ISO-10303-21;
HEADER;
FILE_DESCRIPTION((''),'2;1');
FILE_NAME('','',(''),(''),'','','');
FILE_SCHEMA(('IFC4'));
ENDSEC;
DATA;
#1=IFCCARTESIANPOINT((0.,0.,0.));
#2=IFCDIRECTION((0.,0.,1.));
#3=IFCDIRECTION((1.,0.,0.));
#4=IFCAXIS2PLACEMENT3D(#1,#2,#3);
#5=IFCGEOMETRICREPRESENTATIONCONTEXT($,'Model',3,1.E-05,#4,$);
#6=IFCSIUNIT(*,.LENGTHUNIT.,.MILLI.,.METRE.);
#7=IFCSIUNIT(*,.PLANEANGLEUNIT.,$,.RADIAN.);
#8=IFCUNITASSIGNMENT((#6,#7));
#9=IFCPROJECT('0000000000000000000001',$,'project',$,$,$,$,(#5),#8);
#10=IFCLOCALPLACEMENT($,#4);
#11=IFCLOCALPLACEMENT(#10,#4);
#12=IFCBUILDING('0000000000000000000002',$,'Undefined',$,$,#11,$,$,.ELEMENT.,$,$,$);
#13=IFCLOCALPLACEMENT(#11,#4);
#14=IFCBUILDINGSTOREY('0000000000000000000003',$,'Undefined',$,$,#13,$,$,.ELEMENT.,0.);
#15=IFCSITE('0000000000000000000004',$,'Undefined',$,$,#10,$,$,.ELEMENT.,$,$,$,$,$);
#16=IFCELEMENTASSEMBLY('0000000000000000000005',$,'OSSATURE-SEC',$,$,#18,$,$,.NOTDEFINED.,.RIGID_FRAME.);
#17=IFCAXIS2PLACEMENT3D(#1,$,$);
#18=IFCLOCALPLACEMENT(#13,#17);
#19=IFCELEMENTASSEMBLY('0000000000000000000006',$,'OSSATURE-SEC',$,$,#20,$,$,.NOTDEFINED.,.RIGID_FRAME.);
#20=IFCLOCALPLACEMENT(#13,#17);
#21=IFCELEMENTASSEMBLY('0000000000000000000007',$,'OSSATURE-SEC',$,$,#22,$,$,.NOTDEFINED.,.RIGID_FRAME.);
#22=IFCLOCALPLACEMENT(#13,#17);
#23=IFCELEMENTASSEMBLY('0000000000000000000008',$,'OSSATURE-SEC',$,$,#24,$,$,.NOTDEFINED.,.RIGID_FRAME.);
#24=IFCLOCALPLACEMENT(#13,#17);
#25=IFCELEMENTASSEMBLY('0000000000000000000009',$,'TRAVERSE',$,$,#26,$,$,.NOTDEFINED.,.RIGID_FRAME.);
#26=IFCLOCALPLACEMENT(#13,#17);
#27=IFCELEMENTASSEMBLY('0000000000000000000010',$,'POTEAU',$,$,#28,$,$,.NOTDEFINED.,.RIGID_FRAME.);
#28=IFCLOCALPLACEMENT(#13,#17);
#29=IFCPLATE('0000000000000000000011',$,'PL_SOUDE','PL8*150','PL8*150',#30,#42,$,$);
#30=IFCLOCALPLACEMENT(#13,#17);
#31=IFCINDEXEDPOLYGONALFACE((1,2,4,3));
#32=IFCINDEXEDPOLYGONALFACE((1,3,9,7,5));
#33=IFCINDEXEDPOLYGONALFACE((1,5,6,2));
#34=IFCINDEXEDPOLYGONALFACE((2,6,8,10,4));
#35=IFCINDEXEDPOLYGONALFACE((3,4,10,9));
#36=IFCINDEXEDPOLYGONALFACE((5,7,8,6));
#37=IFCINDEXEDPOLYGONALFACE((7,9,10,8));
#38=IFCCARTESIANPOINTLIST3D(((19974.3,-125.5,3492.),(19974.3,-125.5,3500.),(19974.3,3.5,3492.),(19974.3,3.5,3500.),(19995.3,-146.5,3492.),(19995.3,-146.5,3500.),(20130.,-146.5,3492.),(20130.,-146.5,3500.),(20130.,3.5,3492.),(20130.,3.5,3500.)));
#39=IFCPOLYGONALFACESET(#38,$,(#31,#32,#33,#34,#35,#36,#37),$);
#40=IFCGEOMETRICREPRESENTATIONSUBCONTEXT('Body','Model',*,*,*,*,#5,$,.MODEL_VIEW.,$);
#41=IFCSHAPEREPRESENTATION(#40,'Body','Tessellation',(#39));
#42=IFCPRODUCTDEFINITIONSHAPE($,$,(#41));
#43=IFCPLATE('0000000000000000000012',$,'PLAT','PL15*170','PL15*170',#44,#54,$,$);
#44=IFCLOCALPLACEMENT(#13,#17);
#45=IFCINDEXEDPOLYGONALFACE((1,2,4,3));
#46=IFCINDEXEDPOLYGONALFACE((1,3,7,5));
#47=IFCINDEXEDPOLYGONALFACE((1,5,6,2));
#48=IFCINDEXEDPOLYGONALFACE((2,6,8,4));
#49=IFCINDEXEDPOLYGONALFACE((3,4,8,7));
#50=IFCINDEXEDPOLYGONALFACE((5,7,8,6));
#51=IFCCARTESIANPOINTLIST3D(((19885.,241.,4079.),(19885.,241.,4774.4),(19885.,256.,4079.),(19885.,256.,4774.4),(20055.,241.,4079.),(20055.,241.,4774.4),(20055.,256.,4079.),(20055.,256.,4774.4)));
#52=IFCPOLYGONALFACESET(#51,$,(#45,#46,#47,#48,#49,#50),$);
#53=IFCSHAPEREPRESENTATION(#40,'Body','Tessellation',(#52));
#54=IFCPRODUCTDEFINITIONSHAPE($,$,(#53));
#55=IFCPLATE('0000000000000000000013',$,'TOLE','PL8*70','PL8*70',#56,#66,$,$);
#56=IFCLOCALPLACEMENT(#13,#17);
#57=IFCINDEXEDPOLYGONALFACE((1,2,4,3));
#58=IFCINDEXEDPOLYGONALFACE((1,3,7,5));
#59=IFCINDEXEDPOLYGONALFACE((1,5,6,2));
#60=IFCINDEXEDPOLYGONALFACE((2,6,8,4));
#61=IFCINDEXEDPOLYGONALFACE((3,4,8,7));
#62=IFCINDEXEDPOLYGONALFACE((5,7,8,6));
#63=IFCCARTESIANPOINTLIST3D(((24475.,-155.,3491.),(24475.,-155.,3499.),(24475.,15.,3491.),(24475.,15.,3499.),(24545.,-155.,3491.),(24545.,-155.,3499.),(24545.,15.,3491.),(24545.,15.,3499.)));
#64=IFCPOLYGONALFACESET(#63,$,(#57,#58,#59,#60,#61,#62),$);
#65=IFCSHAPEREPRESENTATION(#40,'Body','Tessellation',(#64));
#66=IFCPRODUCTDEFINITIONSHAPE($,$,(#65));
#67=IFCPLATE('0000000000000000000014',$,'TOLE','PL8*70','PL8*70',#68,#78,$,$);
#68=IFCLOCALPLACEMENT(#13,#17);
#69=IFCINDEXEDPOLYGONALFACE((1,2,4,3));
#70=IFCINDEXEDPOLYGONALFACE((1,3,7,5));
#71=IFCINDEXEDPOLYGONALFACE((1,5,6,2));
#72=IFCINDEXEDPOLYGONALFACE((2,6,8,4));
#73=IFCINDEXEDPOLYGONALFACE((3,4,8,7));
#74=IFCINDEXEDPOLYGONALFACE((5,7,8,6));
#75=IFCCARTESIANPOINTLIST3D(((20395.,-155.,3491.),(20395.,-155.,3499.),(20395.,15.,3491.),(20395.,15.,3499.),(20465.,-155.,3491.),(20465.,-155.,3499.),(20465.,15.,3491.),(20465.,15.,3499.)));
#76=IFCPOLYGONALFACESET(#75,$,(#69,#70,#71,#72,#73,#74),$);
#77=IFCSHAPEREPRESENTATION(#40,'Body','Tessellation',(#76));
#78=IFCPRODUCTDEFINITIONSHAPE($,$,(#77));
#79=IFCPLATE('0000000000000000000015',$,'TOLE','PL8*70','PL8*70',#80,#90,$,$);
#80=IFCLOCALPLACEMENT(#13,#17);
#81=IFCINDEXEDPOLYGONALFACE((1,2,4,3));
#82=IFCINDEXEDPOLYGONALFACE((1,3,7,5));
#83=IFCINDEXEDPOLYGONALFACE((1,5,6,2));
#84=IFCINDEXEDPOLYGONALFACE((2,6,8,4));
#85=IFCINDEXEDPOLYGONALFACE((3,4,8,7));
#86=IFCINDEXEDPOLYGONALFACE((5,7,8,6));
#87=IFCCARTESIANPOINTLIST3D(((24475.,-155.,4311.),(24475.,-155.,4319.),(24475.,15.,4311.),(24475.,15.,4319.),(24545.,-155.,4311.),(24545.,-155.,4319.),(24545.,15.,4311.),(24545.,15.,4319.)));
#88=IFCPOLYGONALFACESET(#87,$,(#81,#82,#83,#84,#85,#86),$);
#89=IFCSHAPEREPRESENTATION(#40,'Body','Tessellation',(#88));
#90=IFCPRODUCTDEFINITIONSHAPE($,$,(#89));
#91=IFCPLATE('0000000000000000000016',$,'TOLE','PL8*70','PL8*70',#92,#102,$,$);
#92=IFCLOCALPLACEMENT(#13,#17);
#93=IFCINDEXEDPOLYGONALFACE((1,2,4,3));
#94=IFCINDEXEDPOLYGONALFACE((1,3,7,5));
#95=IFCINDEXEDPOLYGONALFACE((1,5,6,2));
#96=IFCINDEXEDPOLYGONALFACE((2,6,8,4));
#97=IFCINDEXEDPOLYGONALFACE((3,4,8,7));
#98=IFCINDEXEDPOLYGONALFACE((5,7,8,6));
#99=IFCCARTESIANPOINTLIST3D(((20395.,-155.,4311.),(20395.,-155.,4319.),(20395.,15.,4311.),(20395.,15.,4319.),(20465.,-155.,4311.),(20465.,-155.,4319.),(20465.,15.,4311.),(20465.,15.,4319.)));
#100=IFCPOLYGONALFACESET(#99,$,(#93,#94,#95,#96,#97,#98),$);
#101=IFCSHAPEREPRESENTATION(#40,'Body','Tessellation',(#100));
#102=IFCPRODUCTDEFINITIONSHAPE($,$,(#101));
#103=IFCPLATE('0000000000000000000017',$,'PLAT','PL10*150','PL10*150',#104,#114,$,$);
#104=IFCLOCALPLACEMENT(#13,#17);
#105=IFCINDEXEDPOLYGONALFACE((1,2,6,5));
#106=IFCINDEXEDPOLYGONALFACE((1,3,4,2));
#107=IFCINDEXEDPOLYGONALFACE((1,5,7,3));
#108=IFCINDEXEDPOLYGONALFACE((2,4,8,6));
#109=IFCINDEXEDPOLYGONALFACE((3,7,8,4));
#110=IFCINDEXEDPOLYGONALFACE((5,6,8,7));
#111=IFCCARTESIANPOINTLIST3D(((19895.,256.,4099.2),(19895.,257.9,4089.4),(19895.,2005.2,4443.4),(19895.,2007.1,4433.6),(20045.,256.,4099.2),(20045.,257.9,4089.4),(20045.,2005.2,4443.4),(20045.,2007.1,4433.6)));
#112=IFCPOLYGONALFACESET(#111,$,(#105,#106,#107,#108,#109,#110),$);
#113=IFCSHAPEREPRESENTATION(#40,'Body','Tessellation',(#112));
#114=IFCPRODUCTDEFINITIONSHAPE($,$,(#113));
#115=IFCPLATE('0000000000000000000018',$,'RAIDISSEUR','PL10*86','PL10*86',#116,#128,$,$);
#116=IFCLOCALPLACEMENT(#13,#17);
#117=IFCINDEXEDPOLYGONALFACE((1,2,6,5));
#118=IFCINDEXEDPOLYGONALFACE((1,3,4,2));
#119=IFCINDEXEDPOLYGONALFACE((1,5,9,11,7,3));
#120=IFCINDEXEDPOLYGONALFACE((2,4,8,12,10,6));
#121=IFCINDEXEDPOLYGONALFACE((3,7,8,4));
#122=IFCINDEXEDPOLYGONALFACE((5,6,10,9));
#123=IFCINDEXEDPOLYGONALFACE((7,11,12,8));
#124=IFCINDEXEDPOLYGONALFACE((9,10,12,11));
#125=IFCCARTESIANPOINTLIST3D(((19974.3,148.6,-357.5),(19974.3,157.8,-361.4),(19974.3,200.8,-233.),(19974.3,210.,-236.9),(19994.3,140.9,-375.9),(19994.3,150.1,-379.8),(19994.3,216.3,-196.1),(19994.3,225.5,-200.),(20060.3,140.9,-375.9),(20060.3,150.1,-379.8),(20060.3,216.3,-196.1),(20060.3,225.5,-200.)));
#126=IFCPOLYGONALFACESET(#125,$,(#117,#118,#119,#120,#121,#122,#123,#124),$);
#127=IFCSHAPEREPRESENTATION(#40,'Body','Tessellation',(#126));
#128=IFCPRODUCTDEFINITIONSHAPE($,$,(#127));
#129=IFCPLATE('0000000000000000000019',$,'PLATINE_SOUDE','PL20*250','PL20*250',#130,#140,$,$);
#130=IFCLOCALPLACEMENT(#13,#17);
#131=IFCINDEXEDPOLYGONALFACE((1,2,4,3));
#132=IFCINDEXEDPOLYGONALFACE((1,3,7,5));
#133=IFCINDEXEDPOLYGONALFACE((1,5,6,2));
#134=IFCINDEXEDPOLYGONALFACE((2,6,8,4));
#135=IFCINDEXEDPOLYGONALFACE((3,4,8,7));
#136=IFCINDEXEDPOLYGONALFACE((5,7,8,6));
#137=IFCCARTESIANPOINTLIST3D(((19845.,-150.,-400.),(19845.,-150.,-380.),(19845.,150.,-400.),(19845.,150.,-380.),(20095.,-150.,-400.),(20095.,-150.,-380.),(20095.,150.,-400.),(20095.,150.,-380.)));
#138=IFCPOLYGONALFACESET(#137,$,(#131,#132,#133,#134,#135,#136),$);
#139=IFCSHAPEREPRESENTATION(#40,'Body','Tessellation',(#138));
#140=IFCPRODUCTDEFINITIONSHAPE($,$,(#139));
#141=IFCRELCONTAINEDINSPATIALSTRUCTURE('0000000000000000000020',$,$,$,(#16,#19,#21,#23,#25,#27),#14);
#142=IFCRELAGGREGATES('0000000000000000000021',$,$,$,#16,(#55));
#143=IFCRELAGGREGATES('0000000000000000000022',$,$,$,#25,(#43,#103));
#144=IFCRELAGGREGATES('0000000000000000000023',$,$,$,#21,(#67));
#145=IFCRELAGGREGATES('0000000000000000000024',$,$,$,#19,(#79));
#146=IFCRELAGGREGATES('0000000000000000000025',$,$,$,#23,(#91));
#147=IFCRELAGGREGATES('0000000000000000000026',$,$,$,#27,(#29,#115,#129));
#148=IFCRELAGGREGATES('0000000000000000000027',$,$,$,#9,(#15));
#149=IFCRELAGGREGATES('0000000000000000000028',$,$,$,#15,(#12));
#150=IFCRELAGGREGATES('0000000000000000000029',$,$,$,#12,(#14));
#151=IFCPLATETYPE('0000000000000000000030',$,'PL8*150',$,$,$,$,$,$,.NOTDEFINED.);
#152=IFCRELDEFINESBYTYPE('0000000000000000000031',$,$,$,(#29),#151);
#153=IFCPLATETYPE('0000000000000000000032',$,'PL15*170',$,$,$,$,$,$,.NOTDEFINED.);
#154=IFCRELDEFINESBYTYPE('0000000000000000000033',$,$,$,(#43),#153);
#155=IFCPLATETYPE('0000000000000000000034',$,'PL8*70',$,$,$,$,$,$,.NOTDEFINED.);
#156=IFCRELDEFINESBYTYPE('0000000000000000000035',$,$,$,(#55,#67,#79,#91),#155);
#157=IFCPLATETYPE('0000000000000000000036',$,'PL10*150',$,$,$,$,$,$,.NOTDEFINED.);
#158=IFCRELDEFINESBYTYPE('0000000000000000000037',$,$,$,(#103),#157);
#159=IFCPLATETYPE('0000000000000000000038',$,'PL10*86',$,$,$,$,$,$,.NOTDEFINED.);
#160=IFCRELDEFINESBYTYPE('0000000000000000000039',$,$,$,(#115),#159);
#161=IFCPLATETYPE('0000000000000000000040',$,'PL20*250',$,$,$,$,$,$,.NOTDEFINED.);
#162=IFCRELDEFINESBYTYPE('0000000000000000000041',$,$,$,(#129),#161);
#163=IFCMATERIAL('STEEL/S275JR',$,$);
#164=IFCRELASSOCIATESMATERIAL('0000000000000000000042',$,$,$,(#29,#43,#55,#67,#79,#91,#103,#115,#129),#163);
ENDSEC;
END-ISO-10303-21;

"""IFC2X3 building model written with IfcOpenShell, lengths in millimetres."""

from ifc_helpers import new_model, si_unit, frame, origin_with_axes, place, context, subcontext, project, spatial, polyline, outline, extrude, material, type_object, element, aggregate, save


model = new_model("IFC2X3")

# Units and contexts
model_context = context("Model", 3, precision=1e-05, world=origin_with_axes())
body_context = subcontext(model_context, "Body", "Model", "MODEL_VIEW")
ifc_project = project(units=[si_unit("LENGTHUNIT", "METRE", prefix="MILLI"), si_unit("PLANEANGLEUNIT", "RADIAN")], contexts=[model_context])

# Site, building, storey
site_placement = place(None, origin_with_axes())
site = spatial("IfcSite", under=ifc_project, at=site_placement, Name="Undefined", CompositionType="ELEMENT")
building_placement = place(site_placement, origin_with_axes())
building = spatial("IfcBuilding", under=site, at=building_placement, Name="Undefined", CompositionType="ELEMENT")
storey_placement = place(building_placement, origin_with_axes())
storey = spatial("IfcBuildingStorey", under=building, at=storey_placement, Name="Undefined", CompositionType="ELEMENT", Elevation=0.0)

# Element assemblies
assembly_1_placement = place(storey_placement, origin_with_axes())
assembly_1 = element("IfcElementAssembly", 1, at=assembly_1_placement, inside=storey, Name="OSSATURE-SEC", AssemblyPlace="NOTDEFINED", PredefinedType="RIGID_FRAME")
ifc_material_1 = material(Name="STEEL/S275JR")
assembly_2_placement = place(storey_placement, origin_with_axes())
assembly_2 = element("IfcElementAssembly", 2, at=assembly_2_placement, inside=storey, Name="OSSATURE-SEC", AssemblyPlace="NOTDEFINED", PredefinedType="RIGID_FRAME")

# Element assemblies
assembly_3_placement = place(storey_placement, origin_with_axes())
assembly_3 = element("IfcElementAssembly", 3, at=assembly_3_placement, inside=storey, Name="OSSATURE-SEC", AssemblyPlace="NOTDEFINED", PredefinedType="RIGID_FRAME")
assembly_4_placement = place(storey_placement, origin_with_axes())
assembly_4 = element("IfcElementAssembly", 4, at=assembly_4_placement, inside=storey, Name="OSSATURE-SEC", AssemblyPlace="NOTDEFINED", PredefinedType="RIGID_FRAME")
assembly_5_placement = place(storey_placement, origin_with_axes())
assembly_5 = element("IfcElementAssembly", 5, at=assembly_5_placement, inside=storey, Name="TRAVERSE", AssemblyPlace="NOTDEFINED", PredefinedType="RIGID_FRAME")

# Element assembly, plate
assembly_6_placement = place(storey_placement, origin_with_axes())
assembly_6 = element("IfcElementAssembly", 6, at=assembly_6_placement, inside=storey, Name="POTEAU", AssemblyPlace="NOTDEFINED", PredefinedType="RIGID_FRAME")
plate_type_1 = type_object("IfcPlateType", Name="PL8*150", PredefinedType="NOTDEFINED")
plate_1_placement = place(assembly_6_placement, frame((19974.3, -146.5, 3496.0), z_axis=(0.0, 0.0, 1.0), x_axis=(1.0, 0.0, 0.0)))
plate_1 = element("IfcPlate", 7, at=plate_1_placement, type_object=plate_type_1, material=ifc_material_1, Name="PL_SOUDE", Description="PL8*150", ObjectType="PL8*150", context=body_context, shape_type="SweptSolid", body=[
    extrude(outline(polyline([(0.0, 21.0), (21.0, 0.0), (155.7, 0.0), (155.7, 150.0), (0.0, 150.0), (0.0, 21.0)])), frame((0.0, 0.0, -4.0), z_axis=(0.0, 0.0, 1.0), x_axis=(1.0, 0.0, 0.0)), (0.0, 0.0, 1.0), 8.0),
])

# Plates
plate_type_2 = type_object("IfcPlateType", Name="PL15*170", PredefinedType="NOTDEFINED")
plate_2_placement = place(assembly_5_placement, frame((19970.0, 248.5, 4079.0), z_axis=(0.0, 1.0, 0.0), x_axis=(0.0, 0.0, 1.0)))
plate_2 = element("IfcPlate", 8, at=plate_2_placement, type_object=plate_type_2, material=ifc_material_1, Name="PLAT", Description="PL15*170", ObjectType="PL15*170", context=body_context, shape_type="SweptSolid", body=[
    extrude(outline(polyline([(0.0, -85.0), (0.0, 85.0), (695.3, 85.0), (695.3, -85.0), (0.0, -85.0)])), frame((0.0, 0.0, -7.5), z_axis=(0.0, 0.0, 1.0), x_axis=(1.0, 0.0, 0.0)), (0.0, 0.0, 1.0), 15.0),
])
plate_type_3 = type_object("IfcPlateType", Name="PL8*70", PredefinedType="NOTDEFINED")
plate_3_placement = place(assembly_1_placement, frame((24510.0, 15.0, 3495.0), z_axis=(0.0, 0.0, 1.0), x_axis=(0.0, -1.0, 0.0)))
plate_3 = element("IfcPlate", 9, at=plate_3_placement, type_object=plate_type_3, material=ifc_material_1, Name="TOLE", Description="PL8*70", ObjectType="PL8*70", context=body_context, shape_type="SweptSolid", body=[
    extrude(outline(polyline([(170.0, -35.0), (0.0, -35.0), (0.0, 35.0), (170.0, 35.0), (170.0, -35.0)])), frame((0.0, 0.0, -4.0), z_axis=(0.0, 0.0, 1.0), x_axis=(1.0, 0.0, 0.0)), (0.0, 0.0, 1.0), 8.0),
])
aggregate(assembly_1, [plate_3])
plate_4_placement = place(assembly_3_placement, frame((20430.0, 15.0, 3495.0), z_axis=(0.0, 0.0, -1.0), x_axis=(0.0, -1.0, 0.0)))
plate_4 = element("IfcPlate", 10, at=plate_4_placement, type_object=plate_type_3, material=ifc_material_1, Name="TOLE", Description="PL8*70", ObjectType="PL8*70", context=body_context, shape_type="SweptSolid", body=[
    extrude(outline(polyline([(170.0, 35.0), (170.0, -35.0), (0.0, -35.0), (0.0, 35.0), (170.0, 35.0)])), frame((0.0, 0.0, -4.0), z_axis=(0.0, 0.0, 1.0), x_axis=(1.0, 0.0, 0.0)), (0.0, 0.0, 1.0), 8.0),
])
plate_5_placement = place(assembly_2_placement, frame((24510.0, 15.0, 4315.0), z_axis=(0.0, 0.0, 1.0), x_axis=(0.0, -1.0, 0.0)))
plate_5 = element("IfcPlate", 11, at=plate_5_placement, type_object=plate_type_3, material=ifc_material_1, Name="TOLE", Description="PL8*70", ObjectType="PL8*70", context=body_context, shape_type="SweptSolid", body=[
    extrude(outline(polyline([(170.0, -35.0), (0.0, -35.0), (0.0, 35.0), (170.0, 35.0), (170.0, -35.0)])), frame((0.0, 0.0, -4.0), z_axis=(0.0, 0.0, 1.0), x_axis=(1.0, 0.0, 0.0)), (0.0, 0.0, 1.0), 8.0),
])
plate_6_placement = place(assembly_4_placement, frame((20430.0, 15.0, 4315.0), z_axis=(0.0, 0.0, -1.0), x_axis=(0.0, -1.0, 0.0)))
plate_6 = element("IfcPlate", 12, at=plate_6_placement, type_object=plate_type_3, material=ifc_material_1, Name="TOLE", Description="PL8*70", ObjectType="PL8*70", context=body_context, shape_type="SweptSolid", body=[
    extrude(outline(polyline([(170.0, 35.0), (170.0, -35.0), (0.0, -35.0), (0.0, 35.0), (170.0, 35.0)])), frame((0.0, 0.0, -4.0), z_axis=(0.0, 0.0, 1.0), x_axis=(1.0, 0.0, 0.0)), (0.0, 0.0, 1.0), 8.0),
])
plate_type_4 = type_object("IfcPlateType", Name="PL10*150", PredefinedType="NOTDEFINED")
plate_7_placement = place(assembly_5_placement, frame((19970.0, 257.0, 4094.3), z_axis=(0.0, 0.193091, -0.981181), x_axis=(0.0, 0.981181, 0.193091)))
plate_7 = element("IfcPlate", 13, at=plate_7_placement, type_object=plate_type_4, material=ifc_material_1, Name="PLAT", Description="PL10*150", ObjectType="PL10*150", context=body_context, shape_type="SweptSolid", body=[
    extrude(outline(polyline([(0.0, -75.0), (0.0, 75.0), (1782.7, 75.0), (1782.7, -75.0), (0.0, -75.0)])), frame((0.0, 0.0, -5.0), z_axis=(0.0, 0.0, 1.0), x_axis=(1.0, 0.0, 0.0)), (0.0, 0.0, 1.0), 10.0),
])
plate_type_5 = type_object("IfcPlateType", Name="PL10*86", PredefinedType="NOTDEFINED")
plate_8_placement = place(assembly_6_placement, frame((20060.3, 145.5, -377.9), z_axis=(0.0, 0.922165, -0.386797), x_axis=(-1.0, 0.0, 0.0)))
plate_8 = element("IfcPlate", 14, at=plate_8_placement, type_object=plate_type_5, material=ifc_material_1, Name="RAIDISSEUR", Description="PL10*86", ObjectType="PL10*86", context=body_context, shape_type="SweptSolid", body=[
    extrude(outline(polyline([(0.0, 0.0), (66.0, 0.0), (86.0, 20.0), (86.0, 155.0), (66.0, 195.0), (0.0, 195.0), (0.0, 0.0)])), frame((0.0, 0.0, -5.0), z_axis=(0.0, 0.0, 1.0), x_axis=(1.0, 0.0, 0.0)), (0.0, 0.0, 1.0), 10.0),
])
plate_type_6 = type_object("IfcPlateType", Name="PL20*250", PredefinedType="NOTDEFINED")
plate_9_placement = place(assembly_6_placement, frame((19970.0, -150.0, -390.0), z_axis=(0.0, 0.0, 1.0), x_axis=(0.0, 1.0, 0.0)))
plate_9 = element("IfcPlate", 15, at=plate_9_placement, type_object=plate_type_6, material=ifc_material_1, Name="PLATINE_SOUDE", Description="PL20*250", ObjectType="PL20*250", context=body_context, shape_type="SweptSolid", body=[
    extrude(outline(polyline([(0.0, 125.0), (300.0, 125.0), (300.0, -125.0), (0.0, -125.0), (0.0, 125.0)])), frame((0.0, 0.0, -10.0), z_axis=(0.0, 0.0, 1.0), x_axis=(1.0, 0.0, 0.0)), (0.0, 0.0, 1.0), 20.0),
])
aggregate(assembly_5, [plate_2, plate_7])

aggregate(assembly_3, [plate_4])
aggregate(assembly_2, [plate_5])
aggregate(assembly_4, [plate_6])

aggregate(assembly_6, [plate_1, plate_8, plate_9])

save(model, "model.ifc")
